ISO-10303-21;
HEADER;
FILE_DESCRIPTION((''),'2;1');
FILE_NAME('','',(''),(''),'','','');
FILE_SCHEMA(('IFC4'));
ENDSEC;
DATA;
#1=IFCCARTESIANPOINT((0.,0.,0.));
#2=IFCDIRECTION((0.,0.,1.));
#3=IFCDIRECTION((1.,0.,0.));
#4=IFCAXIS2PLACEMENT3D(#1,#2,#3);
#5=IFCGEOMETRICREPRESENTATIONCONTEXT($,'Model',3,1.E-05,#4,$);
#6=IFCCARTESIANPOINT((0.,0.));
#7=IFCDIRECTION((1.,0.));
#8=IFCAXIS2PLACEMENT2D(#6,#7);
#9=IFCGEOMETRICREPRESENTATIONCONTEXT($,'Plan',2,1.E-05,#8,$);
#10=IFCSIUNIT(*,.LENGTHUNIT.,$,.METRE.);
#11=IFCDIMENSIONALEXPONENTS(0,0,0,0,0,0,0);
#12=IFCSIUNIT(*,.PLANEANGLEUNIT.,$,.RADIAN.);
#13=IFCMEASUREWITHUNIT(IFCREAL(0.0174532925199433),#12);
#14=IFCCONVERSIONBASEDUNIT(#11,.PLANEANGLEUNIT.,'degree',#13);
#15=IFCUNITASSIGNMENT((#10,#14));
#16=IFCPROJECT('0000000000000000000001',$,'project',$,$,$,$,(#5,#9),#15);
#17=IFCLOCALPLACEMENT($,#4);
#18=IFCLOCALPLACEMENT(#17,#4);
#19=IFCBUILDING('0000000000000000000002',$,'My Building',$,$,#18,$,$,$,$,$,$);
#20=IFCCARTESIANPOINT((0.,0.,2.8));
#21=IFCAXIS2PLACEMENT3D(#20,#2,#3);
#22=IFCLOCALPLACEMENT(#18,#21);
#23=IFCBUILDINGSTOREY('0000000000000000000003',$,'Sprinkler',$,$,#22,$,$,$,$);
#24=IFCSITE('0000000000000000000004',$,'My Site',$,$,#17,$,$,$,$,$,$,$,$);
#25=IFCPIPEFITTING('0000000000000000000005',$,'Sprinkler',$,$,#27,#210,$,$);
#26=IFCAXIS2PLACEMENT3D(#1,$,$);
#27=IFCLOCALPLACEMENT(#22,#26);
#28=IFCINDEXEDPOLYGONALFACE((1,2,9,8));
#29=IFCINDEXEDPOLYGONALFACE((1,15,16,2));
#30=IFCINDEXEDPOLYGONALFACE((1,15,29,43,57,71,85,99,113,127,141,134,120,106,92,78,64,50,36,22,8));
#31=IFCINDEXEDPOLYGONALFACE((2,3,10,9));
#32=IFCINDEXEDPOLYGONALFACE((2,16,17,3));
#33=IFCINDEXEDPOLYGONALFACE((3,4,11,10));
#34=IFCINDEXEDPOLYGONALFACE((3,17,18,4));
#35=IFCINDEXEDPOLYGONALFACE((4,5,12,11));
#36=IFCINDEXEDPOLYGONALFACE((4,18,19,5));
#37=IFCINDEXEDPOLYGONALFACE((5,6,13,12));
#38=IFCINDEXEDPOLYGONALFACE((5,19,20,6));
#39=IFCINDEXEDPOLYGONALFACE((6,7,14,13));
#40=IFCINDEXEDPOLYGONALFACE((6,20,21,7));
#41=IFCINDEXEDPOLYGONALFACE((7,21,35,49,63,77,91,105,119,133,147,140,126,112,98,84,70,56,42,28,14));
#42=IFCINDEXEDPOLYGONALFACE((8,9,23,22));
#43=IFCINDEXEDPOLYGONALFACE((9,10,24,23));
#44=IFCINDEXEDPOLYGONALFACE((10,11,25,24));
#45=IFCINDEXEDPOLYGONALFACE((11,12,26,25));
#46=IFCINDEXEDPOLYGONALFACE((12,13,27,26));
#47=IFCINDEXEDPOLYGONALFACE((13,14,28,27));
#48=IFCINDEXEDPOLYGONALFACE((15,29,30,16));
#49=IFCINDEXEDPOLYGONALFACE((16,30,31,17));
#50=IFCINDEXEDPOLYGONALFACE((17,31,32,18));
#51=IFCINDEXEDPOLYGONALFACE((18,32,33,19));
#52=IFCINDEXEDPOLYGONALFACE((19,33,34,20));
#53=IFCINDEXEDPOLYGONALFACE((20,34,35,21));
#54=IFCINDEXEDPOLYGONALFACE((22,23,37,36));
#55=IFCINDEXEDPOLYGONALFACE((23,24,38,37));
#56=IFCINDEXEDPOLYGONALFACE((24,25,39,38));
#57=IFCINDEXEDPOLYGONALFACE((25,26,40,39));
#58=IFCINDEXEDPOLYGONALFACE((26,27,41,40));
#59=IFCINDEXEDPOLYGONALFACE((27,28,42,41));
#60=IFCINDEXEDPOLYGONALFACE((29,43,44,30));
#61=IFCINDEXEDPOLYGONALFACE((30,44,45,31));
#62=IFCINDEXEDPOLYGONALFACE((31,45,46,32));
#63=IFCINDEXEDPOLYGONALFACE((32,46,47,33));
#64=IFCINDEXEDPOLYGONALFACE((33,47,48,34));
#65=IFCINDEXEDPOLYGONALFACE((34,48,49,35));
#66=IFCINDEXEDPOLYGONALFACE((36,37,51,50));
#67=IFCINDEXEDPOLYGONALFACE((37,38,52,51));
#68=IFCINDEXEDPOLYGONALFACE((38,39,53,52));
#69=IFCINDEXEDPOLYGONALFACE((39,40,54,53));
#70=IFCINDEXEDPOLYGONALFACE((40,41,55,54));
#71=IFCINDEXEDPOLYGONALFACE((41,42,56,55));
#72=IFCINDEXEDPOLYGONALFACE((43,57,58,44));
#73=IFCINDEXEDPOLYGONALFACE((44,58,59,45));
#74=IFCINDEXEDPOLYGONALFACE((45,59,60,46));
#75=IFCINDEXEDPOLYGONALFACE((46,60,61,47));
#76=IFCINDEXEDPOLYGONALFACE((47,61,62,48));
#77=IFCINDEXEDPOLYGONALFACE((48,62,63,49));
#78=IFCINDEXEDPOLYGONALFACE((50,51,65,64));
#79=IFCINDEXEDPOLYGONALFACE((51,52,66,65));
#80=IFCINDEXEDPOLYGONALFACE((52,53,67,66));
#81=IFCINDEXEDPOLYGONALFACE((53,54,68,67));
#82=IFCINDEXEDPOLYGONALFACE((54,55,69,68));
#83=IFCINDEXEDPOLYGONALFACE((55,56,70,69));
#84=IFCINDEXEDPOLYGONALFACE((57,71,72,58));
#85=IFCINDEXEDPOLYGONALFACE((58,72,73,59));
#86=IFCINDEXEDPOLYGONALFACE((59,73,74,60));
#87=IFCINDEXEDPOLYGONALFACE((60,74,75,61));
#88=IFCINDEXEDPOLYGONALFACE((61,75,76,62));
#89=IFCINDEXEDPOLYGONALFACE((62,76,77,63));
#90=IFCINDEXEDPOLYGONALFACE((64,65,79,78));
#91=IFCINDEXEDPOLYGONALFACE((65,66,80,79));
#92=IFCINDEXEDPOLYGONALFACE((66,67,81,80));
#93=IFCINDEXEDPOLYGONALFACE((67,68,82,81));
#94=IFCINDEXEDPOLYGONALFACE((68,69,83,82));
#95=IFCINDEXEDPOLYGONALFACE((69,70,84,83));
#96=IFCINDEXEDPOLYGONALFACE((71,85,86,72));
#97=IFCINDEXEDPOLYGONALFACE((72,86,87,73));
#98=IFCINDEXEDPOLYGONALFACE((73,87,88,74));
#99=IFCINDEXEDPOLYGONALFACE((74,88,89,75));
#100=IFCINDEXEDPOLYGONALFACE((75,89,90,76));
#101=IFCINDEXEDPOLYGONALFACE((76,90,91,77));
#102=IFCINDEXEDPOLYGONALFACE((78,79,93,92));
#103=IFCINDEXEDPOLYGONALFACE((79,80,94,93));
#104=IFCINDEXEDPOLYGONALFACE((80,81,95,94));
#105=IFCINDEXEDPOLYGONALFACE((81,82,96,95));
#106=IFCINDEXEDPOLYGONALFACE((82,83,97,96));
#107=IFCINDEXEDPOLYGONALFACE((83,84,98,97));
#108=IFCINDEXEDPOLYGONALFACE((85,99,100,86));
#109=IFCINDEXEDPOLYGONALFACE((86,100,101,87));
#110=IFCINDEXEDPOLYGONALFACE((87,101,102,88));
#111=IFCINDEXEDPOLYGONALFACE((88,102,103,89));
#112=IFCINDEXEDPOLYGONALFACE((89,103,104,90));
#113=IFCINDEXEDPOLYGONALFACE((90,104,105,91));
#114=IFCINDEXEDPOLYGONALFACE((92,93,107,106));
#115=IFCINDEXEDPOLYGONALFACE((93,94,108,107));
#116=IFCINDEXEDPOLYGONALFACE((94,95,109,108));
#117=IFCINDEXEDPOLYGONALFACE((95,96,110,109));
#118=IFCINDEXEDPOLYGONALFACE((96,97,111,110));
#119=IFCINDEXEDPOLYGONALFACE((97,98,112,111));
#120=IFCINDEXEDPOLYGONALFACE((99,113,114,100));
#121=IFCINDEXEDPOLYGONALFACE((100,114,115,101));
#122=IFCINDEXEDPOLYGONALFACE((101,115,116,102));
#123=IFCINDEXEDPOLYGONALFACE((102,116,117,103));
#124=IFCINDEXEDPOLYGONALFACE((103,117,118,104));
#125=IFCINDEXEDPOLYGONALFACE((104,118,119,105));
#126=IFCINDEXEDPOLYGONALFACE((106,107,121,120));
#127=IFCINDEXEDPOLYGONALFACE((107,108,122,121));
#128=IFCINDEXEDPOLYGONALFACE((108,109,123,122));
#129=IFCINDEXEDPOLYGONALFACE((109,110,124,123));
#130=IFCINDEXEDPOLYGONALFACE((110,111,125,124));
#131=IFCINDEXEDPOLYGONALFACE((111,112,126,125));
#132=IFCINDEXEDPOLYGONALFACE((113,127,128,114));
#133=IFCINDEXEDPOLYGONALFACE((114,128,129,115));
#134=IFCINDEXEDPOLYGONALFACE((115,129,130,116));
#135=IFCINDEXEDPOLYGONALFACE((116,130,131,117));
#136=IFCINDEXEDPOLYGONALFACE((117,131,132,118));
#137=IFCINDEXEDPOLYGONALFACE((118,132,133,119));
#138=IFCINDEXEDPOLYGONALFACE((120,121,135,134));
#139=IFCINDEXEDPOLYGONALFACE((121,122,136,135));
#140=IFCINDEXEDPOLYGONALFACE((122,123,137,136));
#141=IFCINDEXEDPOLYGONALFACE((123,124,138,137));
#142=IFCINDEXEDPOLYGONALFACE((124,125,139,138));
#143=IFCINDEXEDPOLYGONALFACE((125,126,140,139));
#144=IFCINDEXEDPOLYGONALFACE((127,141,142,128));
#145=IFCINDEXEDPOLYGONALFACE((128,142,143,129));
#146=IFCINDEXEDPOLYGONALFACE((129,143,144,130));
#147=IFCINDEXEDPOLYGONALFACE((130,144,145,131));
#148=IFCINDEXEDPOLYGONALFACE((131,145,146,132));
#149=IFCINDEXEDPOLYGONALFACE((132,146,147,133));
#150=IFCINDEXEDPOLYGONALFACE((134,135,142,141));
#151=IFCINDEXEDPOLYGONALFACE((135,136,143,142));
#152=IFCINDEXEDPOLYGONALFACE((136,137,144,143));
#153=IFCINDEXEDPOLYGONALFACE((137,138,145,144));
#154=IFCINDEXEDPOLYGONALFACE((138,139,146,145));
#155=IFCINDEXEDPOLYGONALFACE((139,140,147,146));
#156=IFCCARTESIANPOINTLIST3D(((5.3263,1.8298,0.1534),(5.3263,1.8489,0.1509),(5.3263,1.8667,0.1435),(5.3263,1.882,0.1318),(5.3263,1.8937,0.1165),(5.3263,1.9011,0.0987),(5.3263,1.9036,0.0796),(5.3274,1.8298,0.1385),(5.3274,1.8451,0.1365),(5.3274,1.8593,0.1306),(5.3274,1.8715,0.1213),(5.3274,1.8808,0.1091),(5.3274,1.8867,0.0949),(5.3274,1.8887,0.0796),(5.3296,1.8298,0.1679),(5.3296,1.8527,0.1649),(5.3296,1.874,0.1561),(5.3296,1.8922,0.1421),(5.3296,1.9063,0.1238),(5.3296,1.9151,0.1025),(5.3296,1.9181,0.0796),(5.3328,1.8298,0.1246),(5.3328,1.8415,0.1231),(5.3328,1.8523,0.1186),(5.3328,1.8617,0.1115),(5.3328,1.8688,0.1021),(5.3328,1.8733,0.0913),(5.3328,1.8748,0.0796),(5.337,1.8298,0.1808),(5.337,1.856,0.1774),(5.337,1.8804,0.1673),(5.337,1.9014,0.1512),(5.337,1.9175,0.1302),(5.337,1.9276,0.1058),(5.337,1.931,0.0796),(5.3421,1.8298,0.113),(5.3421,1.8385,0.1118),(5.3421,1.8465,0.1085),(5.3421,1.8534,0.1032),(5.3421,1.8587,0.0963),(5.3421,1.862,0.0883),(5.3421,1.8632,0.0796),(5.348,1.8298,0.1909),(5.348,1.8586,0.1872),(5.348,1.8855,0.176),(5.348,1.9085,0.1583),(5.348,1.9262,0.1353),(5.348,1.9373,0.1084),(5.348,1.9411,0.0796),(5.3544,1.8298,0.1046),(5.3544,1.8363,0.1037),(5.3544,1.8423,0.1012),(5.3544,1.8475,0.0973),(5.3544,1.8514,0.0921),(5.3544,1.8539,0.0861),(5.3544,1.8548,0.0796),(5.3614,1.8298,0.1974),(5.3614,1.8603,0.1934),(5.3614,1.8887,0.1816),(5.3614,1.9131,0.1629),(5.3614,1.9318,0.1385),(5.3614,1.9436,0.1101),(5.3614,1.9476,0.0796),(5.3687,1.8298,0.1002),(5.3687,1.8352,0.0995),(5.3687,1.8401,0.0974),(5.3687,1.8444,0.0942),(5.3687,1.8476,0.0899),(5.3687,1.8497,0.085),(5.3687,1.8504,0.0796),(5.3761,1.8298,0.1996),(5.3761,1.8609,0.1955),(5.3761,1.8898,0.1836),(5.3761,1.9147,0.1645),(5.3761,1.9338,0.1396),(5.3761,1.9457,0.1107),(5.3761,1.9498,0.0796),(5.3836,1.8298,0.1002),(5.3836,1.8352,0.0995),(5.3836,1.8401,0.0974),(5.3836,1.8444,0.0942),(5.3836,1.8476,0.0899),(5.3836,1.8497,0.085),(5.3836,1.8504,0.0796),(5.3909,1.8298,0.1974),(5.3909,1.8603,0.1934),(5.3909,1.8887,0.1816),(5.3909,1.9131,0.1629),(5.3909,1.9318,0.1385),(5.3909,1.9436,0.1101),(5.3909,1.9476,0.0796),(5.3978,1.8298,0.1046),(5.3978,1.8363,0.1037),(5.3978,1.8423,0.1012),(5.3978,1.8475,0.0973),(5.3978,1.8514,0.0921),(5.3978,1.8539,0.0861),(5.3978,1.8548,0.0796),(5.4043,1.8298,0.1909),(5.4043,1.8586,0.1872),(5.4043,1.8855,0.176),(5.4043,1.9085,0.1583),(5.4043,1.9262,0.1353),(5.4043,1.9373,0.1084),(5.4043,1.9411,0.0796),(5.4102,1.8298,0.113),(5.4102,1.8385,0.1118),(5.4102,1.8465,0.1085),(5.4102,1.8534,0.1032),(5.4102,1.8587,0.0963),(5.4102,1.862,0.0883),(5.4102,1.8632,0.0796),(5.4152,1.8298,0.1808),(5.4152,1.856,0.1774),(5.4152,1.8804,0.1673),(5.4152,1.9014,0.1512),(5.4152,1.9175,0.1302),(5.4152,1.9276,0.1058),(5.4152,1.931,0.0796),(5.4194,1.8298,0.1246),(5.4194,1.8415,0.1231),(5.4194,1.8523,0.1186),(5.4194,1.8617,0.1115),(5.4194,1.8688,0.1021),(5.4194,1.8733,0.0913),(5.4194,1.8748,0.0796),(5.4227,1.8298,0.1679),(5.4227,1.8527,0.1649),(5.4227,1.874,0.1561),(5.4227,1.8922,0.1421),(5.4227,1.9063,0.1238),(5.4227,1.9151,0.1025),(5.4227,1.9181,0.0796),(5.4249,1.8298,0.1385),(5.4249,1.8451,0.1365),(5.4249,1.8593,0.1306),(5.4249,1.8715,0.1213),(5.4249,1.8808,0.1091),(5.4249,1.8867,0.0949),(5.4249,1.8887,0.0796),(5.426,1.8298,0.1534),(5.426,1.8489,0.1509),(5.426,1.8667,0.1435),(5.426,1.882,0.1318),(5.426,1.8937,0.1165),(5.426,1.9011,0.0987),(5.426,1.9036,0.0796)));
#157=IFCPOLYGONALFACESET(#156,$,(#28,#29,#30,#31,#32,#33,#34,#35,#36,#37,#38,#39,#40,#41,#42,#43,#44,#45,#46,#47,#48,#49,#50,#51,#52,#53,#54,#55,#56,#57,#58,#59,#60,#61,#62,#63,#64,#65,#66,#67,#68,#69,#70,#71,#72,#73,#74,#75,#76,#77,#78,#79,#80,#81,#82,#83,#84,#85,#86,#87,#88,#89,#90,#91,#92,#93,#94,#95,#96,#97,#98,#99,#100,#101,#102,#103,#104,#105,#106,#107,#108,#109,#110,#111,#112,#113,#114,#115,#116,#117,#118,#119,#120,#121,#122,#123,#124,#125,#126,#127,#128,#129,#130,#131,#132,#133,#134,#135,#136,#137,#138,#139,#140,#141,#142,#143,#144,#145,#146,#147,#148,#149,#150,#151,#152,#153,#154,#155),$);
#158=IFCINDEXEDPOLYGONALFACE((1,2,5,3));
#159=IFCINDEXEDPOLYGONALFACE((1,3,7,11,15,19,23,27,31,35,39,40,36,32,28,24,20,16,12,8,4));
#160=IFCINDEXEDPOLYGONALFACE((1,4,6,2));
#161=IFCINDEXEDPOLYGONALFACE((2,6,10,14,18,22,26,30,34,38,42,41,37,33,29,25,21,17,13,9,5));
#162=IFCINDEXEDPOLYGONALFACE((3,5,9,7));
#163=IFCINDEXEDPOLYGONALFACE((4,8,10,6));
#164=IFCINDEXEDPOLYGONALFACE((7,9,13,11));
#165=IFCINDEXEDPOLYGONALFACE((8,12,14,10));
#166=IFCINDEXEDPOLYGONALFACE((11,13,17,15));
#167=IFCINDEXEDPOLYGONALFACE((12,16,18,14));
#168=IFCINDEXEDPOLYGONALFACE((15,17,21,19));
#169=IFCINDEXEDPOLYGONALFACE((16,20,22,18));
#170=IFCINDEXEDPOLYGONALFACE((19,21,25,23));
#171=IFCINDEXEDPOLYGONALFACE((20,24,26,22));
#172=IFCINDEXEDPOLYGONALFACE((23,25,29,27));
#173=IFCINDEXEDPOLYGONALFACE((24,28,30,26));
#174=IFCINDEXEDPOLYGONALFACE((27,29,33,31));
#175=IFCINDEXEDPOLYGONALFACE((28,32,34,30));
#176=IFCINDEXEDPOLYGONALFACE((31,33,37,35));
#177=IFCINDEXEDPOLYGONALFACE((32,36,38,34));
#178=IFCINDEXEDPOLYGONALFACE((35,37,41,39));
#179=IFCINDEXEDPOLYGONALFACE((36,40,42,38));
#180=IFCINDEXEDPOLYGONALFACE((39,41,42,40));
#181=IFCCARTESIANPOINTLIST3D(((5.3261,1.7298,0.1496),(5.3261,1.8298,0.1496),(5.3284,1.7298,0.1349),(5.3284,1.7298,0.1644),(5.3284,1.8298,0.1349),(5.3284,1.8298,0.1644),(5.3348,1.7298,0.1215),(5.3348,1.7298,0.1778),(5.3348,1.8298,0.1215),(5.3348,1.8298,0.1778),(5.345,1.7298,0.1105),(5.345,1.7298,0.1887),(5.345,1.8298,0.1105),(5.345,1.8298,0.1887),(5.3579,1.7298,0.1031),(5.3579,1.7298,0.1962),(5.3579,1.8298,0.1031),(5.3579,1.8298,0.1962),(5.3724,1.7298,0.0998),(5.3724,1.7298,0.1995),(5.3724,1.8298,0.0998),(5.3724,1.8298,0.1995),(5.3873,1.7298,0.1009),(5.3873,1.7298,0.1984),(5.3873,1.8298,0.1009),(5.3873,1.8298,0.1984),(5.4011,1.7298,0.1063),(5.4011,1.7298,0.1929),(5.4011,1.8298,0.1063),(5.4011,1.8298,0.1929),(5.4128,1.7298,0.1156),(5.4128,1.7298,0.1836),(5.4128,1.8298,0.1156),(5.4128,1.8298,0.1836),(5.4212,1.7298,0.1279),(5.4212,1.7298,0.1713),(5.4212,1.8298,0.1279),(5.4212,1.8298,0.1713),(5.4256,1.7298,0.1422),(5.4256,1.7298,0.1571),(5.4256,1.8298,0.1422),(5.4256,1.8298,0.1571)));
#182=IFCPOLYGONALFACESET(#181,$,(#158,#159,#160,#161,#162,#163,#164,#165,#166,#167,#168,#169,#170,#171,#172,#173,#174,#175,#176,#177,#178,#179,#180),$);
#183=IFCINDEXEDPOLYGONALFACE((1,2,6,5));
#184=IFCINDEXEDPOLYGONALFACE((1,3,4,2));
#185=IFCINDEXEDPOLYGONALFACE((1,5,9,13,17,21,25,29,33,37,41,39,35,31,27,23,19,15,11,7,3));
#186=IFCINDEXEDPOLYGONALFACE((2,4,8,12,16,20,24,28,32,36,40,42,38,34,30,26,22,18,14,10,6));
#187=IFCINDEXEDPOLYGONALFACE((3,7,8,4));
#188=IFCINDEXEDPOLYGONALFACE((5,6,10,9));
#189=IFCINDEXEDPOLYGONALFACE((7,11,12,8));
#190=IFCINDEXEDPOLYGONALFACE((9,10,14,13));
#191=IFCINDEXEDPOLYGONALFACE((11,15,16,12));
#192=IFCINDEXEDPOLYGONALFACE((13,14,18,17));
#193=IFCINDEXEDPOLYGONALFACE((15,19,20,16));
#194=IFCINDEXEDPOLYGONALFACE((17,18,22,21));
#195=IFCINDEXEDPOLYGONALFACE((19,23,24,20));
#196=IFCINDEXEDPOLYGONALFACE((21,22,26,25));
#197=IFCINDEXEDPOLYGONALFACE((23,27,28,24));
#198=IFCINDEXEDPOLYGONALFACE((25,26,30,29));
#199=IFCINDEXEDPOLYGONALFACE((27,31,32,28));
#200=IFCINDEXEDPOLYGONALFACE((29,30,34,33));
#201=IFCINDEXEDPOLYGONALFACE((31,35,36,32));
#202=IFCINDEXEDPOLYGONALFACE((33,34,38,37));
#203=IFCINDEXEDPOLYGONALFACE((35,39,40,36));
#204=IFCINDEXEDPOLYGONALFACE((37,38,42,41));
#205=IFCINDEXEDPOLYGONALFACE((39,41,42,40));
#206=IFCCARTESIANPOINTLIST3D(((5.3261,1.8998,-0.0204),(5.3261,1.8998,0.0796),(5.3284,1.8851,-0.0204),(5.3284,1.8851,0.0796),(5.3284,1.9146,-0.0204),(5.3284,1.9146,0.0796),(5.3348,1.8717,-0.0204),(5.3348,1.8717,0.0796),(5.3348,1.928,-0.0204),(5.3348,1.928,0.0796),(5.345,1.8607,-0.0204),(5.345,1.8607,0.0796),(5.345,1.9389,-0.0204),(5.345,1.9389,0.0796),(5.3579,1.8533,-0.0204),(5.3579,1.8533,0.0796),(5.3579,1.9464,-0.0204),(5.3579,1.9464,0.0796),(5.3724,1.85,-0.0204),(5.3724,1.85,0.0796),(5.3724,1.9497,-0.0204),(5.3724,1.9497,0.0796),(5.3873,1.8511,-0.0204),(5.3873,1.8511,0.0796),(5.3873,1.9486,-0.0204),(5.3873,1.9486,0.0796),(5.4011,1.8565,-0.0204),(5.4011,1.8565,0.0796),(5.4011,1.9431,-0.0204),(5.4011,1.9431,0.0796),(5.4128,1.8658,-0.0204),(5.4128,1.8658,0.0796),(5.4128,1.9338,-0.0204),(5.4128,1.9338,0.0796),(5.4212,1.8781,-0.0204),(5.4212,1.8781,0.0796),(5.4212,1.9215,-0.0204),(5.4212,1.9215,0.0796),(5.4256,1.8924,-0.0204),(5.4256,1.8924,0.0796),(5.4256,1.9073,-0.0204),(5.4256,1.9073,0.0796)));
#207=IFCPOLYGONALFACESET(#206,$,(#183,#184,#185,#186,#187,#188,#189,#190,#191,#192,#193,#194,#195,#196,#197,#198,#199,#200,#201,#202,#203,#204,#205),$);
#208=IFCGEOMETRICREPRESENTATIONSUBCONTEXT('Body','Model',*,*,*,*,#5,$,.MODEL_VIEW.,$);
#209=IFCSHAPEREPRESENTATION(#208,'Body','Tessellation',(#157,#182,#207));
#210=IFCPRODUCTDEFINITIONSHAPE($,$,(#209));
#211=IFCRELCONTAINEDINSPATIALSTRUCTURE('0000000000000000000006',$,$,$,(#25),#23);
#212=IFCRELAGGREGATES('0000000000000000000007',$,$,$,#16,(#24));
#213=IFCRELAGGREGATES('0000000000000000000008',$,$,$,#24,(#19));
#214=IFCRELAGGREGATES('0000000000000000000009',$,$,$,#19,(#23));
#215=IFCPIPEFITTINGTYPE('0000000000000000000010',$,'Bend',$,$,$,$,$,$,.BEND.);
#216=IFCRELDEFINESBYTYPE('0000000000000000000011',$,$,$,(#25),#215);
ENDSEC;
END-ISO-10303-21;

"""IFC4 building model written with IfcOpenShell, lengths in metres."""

from ifc_helpers import new_model, entity, si_unit, converted_unit, frame, origin_with_axes, origin_2d_with_axis, place, context, subcontext, project, spatial, circle, extrude, source, transform, mapped, type_object, type_shapes, element, save


model = new_model("IFC4")

# Units and contexts
model_context = context("Model", 3, precision=1e-05, world=origin_with_axes())
plan_context = context("Plan", 2, precision=1e-05, world=origin_2d_with_axis())
body_context = subcontext(model_context, "Body", "Model", "MODEL_VIEW")
ifc_project = project(units=[si_unit("LENGTHUNIT", "METRE"), converted_unit("PLANEANGLEUNIT", "degree", entity("IfcReal", 0.0174532925199433), si_unit("PLANEANGLEUNIT", "RADIAN"), dimensions=[0, 0, 0, 0, 0, 0, 0])], contexts=[model_context, plan_context])

# Site, building, storey
site_placement = place(None, origin_with_axes())
site = spatial("IfcSite", under=ifc_project, at=site_placement, Name="My Site")
building_placement = place(site_placement, origin_with_axes())
building = spatial("IfcBuilding", under=site, at=building_placement, Name="My Building")
storey_placement = place(building_placement, frame((0.0, 0.0, 2.8), z_axis=(0.0, 0.0, 1.0), x_axis=(1.0, 0.0, 0.0)))
storey = spatial("IfcBuildingStorey", under=building, at=storey_placement, Name="Sprinkler")

# Pipe fitting
pipe_fitting_type_1 = type_object("IfcPipeFittingType", Name="Bend", PredefinedType="BEND")
shared_shape_1 = source(origin_with_axes(), body_context, "Body", "SolidModel", [
    entity("IfcSweptDiskSolid", entity("IfcIndexedPolyCurve", entity("IfcCartesianPointList3D", [[0.0, 0.0, 0.1], [0.0, -0.0205, 0.1495], [0.0, -0.07, 0.17]]), [entity("IfcArcIndex", [1, 2, 3])]), 0.05),
    extrude(circle(Radius=0.05), origin_with_axes(), (0.0, 0.0, 1.0), 0.1),
    extrude(circle(Radius=0.05), frame((0.0, -0.07, 0.17), z_axis=(0.0, -1.0, 0.0), x_axis=(1.0, 0.0, 0.0)), (0.0, 0.0, 1.0), 0.1),
])
type_shapes(pipe_fitting_type_1, [shared_shape_1])
for number, where, z_axis, x_axis, name in (
    (1, (5.3761, 1.7298, 0.1496), (-0.000001, 1.0, 0.0), (-1.0, -0.000001, 0.0), "Sprinkler"),
):
    element("IfcPipeFitting", number, at=place(storey_placement, frame(where, z_axis=z_axis, x_axis=x_axis)), inside=storey, type_object=pipe_fitting_type_1, Name=name, context=body_context, shape_type="MappedRepresentation", body=[
        mapped(shared_shape_1, transform((0.0, 0.0, 0.0), x_axis=(1.0, 0.0, 0.0), y_axis=(0.0, 1.0, 0.0), z_axis=(0.0, 0.0, 1.0), scale=1.0)),
    ])

save(model, "model.ifc")
